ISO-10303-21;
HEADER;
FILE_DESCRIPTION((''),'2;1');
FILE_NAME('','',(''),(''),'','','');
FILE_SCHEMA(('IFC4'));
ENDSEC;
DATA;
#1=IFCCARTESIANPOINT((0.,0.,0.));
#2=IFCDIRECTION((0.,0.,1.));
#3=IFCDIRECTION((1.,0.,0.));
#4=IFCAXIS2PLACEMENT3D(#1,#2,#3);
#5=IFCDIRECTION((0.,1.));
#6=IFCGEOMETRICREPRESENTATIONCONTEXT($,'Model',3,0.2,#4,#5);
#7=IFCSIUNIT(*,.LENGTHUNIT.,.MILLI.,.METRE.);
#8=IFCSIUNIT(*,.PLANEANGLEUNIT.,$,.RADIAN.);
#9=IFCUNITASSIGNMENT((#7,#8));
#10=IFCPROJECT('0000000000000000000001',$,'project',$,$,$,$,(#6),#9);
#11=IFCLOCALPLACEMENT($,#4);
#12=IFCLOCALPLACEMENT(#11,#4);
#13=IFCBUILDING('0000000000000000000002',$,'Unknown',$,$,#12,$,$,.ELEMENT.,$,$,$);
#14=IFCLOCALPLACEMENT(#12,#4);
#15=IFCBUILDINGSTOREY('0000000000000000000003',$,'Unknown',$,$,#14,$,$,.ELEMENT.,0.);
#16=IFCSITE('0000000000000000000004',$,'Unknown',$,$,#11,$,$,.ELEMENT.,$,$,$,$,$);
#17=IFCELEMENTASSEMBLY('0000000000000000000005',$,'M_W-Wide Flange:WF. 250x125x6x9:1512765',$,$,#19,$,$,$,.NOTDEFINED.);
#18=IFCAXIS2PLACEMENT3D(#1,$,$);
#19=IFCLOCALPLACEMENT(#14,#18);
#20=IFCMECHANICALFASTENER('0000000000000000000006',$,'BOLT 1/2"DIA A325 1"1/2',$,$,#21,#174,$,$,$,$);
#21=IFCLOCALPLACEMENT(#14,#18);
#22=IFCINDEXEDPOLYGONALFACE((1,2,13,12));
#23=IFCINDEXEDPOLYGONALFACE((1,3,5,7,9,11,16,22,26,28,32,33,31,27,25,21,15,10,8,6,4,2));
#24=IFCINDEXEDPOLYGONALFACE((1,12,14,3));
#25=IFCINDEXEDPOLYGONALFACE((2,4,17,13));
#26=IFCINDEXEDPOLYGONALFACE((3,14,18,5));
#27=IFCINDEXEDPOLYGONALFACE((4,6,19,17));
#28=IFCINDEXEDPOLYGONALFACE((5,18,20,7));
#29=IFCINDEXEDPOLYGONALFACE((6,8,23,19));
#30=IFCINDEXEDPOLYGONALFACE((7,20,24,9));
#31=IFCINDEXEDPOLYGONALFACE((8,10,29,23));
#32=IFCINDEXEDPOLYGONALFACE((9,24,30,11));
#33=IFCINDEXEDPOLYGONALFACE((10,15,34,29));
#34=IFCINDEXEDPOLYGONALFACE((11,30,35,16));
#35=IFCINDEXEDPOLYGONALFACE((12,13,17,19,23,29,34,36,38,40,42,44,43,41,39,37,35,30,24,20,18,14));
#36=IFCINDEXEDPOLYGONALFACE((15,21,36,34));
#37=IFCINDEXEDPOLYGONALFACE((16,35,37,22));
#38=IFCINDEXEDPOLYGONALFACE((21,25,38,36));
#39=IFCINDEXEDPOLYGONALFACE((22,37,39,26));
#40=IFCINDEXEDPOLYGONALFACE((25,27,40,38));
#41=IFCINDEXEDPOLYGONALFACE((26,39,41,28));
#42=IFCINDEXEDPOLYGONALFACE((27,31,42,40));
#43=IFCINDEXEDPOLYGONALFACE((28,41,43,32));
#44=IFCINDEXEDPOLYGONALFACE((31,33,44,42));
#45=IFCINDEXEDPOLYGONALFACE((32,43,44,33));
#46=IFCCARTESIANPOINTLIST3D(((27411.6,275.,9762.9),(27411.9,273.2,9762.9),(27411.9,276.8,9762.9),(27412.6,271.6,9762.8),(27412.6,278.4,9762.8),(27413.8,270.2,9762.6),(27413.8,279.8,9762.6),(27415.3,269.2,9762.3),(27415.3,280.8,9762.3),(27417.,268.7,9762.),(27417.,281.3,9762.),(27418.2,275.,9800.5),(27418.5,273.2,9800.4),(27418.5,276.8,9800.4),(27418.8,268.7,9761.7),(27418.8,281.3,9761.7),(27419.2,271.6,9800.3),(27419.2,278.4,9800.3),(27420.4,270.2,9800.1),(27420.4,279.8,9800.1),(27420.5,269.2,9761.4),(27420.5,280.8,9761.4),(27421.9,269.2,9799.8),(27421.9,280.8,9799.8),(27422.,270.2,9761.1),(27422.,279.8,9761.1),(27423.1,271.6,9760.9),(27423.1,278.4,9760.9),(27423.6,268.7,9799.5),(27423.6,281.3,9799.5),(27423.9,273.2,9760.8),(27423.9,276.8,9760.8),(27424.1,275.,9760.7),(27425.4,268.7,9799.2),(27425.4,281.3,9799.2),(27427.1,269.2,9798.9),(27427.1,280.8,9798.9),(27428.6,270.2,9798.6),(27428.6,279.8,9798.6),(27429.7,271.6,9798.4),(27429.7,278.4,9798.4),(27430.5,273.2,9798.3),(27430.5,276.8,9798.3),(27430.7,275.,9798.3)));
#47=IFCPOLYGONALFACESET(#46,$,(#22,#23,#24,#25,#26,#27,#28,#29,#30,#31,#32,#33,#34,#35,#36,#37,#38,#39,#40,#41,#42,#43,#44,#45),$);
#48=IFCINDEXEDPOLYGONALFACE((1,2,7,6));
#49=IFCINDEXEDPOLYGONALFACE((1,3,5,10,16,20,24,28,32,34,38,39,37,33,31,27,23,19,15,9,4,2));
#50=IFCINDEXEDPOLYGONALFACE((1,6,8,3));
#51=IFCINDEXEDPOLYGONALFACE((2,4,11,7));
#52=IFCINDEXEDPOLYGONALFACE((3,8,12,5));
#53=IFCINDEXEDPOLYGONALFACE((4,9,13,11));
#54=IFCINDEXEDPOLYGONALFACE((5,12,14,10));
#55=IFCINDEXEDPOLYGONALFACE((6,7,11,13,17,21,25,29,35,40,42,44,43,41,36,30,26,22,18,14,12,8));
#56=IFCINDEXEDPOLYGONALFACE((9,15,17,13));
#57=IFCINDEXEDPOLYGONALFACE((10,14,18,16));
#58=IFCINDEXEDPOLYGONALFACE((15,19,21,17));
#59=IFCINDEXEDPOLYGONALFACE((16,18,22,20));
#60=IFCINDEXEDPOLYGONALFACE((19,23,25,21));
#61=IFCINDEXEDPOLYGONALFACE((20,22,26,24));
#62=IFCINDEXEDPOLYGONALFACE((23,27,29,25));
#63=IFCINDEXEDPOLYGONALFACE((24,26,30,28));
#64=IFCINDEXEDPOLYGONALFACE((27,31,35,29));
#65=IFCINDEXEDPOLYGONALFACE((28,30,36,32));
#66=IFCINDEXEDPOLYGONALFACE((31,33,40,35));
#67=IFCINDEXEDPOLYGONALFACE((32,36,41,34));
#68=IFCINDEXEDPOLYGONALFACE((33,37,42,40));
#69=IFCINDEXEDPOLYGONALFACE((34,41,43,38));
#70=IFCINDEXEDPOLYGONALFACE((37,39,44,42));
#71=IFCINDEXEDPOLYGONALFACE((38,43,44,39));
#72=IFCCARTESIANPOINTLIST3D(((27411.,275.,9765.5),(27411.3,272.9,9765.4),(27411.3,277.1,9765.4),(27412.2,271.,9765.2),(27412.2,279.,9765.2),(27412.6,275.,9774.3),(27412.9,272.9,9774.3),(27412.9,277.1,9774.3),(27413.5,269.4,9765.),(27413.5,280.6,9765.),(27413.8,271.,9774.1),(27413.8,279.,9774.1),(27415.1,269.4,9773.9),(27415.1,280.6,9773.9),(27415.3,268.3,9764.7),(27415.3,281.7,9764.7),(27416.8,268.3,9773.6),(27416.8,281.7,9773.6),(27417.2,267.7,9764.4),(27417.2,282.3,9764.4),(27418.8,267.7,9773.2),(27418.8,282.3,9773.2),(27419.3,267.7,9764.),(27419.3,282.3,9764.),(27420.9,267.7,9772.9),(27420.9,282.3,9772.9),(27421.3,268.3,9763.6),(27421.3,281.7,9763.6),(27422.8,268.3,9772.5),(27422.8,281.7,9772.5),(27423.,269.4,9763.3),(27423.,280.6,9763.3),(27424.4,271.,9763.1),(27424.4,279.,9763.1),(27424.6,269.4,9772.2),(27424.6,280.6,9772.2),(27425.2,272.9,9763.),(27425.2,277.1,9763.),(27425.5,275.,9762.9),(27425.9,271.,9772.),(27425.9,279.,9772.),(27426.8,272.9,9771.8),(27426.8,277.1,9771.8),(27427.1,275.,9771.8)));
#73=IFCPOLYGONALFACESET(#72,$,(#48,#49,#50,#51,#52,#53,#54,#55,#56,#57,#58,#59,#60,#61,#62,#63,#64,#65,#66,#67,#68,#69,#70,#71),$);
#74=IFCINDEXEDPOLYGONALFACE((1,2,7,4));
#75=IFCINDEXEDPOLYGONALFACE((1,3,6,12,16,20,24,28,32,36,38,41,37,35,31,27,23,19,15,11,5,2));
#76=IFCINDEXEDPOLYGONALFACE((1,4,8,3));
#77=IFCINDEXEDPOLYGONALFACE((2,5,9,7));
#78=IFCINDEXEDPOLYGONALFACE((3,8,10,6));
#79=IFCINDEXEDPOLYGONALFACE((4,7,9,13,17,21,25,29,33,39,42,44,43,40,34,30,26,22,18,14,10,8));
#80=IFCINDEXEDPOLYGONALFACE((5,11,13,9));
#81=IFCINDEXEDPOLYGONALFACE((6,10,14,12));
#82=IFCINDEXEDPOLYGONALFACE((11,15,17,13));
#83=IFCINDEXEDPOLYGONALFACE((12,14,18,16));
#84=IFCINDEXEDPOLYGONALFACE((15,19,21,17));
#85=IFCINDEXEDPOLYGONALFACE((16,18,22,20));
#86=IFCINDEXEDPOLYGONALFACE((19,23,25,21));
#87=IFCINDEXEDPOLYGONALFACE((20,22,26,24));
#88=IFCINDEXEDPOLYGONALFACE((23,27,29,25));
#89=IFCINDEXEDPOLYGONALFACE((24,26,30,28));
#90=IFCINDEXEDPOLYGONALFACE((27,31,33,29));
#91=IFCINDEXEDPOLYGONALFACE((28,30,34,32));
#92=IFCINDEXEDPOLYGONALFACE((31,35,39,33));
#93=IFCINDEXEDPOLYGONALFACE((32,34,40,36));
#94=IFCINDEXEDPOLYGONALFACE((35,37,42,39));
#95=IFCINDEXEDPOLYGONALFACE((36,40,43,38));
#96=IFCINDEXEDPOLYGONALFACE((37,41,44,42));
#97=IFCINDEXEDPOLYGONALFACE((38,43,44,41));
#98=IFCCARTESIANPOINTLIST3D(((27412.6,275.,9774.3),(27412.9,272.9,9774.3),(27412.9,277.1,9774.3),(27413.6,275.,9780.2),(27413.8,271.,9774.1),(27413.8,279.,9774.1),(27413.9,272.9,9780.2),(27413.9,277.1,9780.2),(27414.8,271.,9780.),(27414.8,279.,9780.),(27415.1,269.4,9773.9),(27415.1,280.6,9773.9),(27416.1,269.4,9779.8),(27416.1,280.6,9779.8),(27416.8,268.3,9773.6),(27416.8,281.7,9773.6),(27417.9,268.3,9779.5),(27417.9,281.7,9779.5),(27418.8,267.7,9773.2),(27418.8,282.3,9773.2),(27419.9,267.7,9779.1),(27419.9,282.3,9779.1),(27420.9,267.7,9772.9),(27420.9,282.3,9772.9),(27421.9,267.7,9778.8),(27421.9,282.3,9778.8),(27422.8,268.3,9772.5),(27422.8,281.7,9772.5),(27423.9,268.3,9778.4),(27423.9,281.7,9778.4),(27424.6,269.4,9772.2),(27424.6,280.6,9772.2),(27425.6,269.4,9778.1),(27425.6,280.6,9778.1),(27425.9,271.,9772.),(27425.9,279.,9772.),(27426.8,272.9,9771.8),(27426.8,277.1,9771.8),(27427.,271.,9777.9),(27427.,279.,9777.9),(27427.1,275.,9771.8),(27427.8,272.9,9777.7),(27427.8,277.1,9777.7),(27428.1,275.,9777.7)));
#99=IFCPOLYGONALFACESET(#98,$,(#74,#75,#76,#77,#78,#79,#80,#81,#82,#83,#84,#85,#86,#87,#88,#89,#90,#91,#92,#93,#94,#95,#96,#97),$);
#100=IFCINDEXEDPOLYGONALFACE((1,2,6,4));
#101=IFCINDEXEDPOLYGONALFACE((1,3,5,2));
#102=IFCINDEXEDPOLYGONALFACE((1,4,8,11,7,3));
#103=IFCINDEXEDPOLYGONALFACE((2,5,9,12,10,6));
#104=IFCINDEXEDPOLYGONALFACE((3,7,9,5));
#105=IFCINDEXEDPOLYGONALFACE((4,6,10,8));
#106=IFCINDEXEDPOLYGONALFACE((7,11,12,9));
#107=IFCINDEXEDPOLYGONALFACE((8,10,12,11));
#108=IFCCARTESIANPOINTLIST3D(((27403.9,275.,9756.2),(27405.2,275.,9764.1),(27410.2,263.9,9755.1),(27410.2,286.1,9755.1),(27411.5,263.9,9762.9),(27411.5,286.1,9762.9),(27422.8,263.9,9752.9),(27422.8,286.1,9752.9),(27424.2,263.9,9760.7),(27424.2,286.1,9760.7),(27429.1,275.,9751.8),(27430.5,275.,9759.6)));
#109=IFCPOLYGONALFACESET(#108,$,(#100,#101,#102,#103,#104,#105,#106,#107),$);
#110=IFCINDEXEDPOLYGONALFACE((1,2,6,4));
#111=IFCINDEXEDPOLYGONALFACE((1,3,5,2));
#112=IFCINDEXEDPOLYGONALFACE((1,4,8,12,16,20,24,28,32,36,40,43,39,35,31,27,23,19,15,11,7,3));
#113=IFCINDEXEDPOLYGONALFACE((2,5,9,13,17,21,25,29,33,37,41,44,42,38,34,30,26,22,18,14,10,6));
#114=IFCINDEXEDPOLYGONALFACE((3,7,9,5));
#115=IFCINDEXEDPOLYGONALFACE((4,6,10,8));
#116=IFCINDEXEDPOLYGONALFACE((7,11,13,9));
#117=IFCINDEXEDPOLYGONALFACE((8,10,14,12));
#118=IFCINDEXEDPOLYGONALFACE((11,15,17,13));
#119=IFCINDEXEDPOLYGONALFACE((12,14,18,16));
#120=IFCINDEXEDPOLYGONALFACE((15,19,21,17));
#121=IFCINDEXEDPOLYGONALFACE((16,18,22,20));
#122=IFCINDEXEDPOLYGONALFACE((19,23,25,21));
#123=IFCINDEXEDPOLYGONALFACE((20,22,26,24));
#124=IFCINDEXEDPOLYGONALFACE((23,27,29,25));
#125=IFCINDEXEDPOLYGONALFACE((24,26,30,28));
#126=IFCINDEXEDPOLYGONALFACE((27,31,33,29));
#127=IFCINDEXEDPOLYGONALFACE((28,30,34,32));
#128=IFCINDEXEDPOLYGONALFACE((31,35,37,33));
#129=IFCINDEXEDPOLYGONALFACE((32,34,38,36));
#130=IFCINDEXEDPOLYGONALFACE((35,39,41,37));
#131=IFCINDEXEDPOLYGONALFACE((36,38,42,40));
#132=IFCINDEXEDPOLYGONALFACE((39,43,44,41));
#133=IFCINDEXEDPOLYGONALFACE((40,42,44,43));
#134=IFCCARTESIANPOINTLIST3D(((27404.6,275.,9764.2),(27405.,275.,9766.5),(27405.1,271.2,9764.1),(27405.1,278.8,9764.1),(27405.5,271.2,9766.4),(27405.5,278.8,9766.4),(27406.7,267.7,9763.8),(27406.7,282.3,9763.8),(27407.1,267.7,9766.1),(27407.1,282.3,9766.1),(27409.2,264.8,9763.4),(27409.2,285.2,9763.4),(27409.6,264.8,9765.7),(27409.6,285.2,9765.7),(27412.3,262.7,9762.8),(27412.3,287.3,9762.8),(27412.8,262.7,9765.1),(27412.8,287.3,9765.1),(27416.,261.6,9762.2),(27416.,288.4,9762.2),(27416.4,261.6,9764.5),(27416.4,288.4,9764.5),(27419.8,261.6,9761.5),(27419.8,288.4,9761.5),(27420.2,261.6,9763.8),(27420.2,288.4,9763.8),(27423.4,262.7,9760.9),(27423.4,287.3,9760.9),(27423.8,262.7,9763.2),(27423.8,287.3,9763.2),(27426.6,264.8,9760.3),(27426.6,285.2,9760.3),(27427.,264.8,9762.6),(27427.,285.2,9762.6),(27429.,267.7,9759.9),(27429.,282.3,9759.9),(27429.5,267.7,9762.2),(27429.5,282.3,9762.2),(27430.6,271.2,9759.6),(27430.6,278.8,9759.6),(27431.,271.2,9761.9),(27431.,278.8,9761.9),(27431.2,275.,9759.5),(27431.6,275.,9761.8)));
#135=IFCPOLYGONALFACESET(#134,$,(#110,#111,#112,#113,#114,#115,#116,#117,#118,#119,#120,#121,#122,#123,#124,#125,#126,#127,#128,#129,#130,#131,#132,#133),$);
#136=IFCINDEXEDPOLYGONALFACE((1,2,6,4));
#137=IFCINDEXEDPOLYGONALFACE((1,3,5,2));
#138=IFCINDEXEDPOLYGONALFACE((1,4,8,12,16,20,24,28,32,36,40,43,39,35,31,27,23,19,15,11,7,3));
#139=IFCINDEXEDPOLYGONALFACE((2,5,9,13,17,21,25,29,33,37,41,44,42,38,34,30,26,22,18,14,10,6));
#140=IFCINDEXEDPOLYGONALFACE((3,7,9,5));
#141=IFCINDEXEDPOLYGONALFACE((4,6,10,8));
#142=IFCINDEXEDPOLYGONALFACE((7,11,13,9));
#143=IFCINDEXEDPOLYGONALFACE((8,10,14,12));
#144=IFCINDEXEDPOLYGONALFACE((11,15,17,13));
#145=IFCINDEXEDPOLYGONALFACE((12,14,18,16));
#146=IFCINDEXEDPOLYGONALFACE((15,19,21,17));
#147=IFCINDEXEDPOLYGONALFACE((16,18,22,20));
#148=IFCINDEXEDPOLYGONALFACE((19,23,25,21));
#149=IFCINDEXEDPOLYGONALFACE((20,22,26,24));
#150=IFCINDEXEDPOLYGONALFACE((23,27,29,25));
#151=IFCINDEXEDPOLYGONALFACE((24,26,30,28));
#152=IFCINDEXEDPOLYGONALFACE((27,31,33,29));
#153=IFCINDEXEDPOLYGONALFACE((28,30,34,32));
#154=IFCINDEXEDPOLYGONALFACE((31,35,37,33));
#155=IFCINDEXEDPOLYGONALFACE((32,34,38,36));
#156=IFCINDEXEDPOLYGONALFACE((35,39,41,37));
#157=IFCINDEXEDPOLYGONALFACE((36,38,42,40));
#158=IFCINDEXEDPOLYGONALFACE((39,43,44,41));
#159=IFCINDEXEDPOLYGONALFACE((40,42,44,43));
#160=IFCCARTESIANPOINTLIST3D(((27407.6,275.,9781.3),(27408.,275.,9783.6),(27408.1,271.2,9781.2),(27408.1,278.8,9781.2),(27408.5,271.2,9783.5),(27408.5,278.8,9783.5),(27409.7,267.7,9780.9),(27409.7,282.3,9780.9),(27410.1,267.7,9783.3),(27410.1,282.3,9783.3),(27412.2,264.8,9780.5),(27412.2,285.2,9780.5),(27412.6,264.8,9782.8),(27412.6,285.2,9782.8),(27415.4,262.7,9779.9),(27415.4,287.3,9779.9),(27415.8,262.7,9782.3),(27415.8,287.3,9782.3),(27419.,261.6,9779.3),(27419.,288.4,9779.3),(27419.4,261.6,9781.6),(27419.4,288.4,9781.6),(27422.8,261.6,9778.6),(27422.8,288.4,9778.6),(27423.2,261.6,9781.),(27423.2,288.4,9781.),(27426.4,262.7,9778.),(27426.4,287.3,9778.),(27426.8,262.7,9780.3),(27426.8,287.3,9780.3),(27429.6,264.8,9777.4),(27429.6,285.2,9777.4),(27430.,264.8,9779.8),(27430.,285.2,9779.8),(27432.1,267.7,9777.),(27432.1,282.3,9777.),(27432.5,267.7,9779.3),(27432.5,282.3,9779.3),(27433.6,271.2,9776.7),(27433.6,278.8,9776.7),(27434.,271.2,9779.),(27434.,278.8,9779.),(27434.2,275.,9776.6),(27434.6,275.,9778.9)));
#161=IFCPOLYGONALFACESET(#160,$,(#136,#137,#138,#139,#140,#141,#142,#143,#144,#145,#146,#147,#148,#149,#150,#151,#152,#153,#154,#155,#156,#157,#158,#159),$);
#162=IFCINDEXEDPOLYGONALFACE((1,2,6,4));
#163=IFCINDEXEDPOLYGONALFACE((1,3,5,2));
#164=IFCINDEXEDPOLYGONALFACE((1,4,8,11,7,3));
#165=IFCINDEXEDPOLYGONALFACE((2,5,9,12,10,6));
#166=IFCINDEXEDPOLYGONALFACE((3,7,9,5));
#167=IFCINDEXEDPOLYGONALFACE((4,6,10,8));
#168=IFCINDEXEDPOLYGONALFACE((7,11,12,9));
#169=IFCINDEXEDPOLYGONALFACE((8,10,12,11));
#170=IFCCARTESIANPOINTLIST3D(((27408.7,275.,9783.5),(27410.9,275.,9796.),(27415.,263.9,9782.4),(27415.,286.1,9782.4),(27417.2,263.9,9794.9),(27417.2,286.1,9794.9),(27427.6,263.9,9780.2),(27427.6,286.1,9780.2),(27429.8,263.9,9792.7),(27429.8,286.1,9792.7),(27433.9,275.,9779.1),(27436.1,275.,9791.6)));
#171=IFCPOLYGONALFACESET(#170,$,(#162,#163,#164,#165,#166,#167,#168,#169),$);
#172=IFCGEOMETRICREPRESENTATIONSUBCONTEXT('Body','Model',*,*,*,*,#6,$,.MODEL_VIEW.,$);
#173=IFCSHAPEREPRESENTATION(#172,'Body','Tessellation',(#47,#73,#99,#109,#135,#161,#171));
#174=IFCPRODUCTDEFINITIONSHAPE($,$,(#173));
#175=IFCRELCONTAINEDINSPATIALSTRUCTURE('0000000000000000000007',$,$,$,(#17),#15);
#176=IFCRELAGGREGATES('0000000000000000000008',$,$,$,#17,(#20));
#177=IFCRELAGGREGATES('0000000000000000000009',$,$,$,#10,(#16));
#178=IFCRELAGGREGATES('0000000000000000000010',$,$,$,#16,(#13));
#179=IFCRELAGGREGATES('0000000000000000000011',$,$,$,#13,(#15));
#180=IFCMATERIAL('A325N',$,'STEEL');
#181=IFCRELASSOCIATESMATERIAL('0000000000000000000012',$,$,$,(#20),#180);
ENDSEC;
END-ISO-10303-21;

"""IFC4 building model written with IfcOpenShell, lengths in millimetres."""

from ifc_helpers import new_model, si_unit, direction, frame, origin_with_axes, place, context, subcontext, project, spatial, line, arc, indexed_curve, outline, extrude, source, transform, mapped, material, element, aggregate, save


model = new_model("IFC4")

# Units and contexts
model_context = context("Model", 3, precision=0.2, world=origin_with_axes(), true_north=direction((0.0, 1.0)))
body_context = subcontext(model_context, "Body", "Model", "MODEL_VIEW")
ifc_project = project(units=[si_unit("LENGTHUNIT", "METRE", prefix="MILLI"), si_unit("PLANEANGLEUNIT", "RADIAN")], contexts=[model_context])

# Site, building, storey
site_placement = place(None, origin_with_axes())
site = spatial("IfcSite", under=ifc_project, at=site_placement, Name="Unknown", CompositionType="ELEMENT")
building_placement = place(site_placement, origin_with_axes())
building = spatial("IfcBuilding", under=site, at=building_placement, Name="Unknown", CompositionType="ELEMENT")
storey_placement = place(building_placement, origin_with_axes())
storey = spatial("IfcBuildingStorey", under=building, at=storey_placement, Name="Unknown", CompositionType="ELEMENT", Elevation=0.0)

# Element assembly, mechanical fastener
assembly_1_placement = place(storey_placement, frame((27430.1, 0.0, 9644.3), z_axis=(0.984808, 0.0, -0.173648), x_axis=(0.0, 1.0, 0.0)))
assembly_1 = element("IfcElementAssembly", 1, at=assembly_1_placement, inside=storey, Name="M_W-Wide Flange:WF. 250x125x6x9:1512765", PredefinedType="NOTDEFINED")
ifc_material_1 = material(Name="A325N", Category="STEEL")
shared_shape = source(origin_with_axes(), body_context, "Body", "SweptSolid", [
    extrude(outline(indexed_curve([(6.3, 0.0), (0.0, 6.3), (-6.3, 0.0), (0.0, -6.3)], segments=[arc(1, 2, 3), arc(3, 4, 1)])), frame((0.0, 0.0, 17.4), z_axis=(0.0, 0.0, -1.0), x_axis=(0.0, 1.0, 0.0)), (0.0, 0.0, 1.0), 38.1),
    extrude(outline(indexed_curve([(7.3, 0.0), (0.0, 7.3), (-7.3, 0.0), (0.0, -7.3)], segments=[arc(1, 2, 3), arc(3, 4, 1)])), frame((0.0, 0.0, 15.0), z_axis=(0.0, 0.0, -1.0), x_axis=(0.0, 1.0, 0.0)), (0.0, 0.0, 1.0), 9.0),
    extrude(outline(indexed_curve([(7.3, 0.0), (0.0, 7.3), (-7.3, 0.0), (0.0, -7.3)], segments=[arc(1, 2, 3), arc(3, 4, 1)])), frame((0.0, 0.0, 6.0), z_axis=(0.0, 0.0, -1.0), x_axis=(0.0, 1.0, 0.0)), (0.0, 0.0, 1.0), 6.0),
    extrude(outline(indexed_curve([(12.8, 0.0), (6.4, 11.1), (-6.4, 11.1), (-12.8, 0.0), (-6.4, -11.1), (6.4, -11.1)], segments=[line(1, 2, 3, 4, 5, 6, 1)])), frame((0.0, 0.0, 25.3), z_axis=(0.0, 0.0, -1.0), x_axis=(0.0, 1.0, 0.0)), (0.0, 0.0, 1.0), 7.9),
    extrude(outline(indexed_curve([(13.5, 0.0), (0.0, 13.5), (-13.5, 0.0), (0.0, -13.5)], segments=[arc(1, 2, 3), arc(3, 4, 1)])), frame((0.0, 0.0, 17.4), z_axis=(0.0, 0.0, -1.0), x_axis=(0.0, 1.0, 0.0)), (0.0, 0.0, 1.0), 2.4),
    extrude(outline(indexed_curve([(13.5, 0.0), (0.0, 13.5), (-13.5, 0.0), (0.0, -13.5)], segments=[arc(1, 2, 3), arc(3, 4, 1)])), frame((0.0, 0.0, 0.0), z_axis=(0.0, 0.0, -1.0), x_axis=(0.0, 1.0, 0.0)), (0.0, 0.0, 1.0), 2.4),
    extrude(outline(indexed_curve([(12.8, 0.0), (6.4, 11.1), (-6.4, 11.1), (-12.8, 0.0), (-6.4, -11.1), (6.4, -11.1)], segments=[line(1, 2, 3, 4, 5, 6, 1)])), frame((0.0, 0.0, -2.4), z_axis=(0.0, 0.0, -1.0), x_axis=(0.0, 1.0, 0.0)), (0.0, 0.0, 1.0), 12.7),
])
mechanical_fastener_1_placement = place(assembly_1_placement, frame((275.0, 131.0, -32.5), z_axis=(0.0, -1.0, 0.0), x_axis=(-1.0, 0.0, 0.0)))
mechanical_fastener_1 = element("IfcMechanicalFastener", 2, at=mechanical_fastener_1_placement, material=ifc_material_1, Name="BOLT 1/2\"DIA A325 1\"1/2", context=body_context, shape_type="MappedRepresentation", body=[
    mapped(shared_shape, transform((0.0, 0.0, 0.0))),
])
aggregate(assembly_1, [mechanical_fastener_1])

save(model, "model.ifc")
